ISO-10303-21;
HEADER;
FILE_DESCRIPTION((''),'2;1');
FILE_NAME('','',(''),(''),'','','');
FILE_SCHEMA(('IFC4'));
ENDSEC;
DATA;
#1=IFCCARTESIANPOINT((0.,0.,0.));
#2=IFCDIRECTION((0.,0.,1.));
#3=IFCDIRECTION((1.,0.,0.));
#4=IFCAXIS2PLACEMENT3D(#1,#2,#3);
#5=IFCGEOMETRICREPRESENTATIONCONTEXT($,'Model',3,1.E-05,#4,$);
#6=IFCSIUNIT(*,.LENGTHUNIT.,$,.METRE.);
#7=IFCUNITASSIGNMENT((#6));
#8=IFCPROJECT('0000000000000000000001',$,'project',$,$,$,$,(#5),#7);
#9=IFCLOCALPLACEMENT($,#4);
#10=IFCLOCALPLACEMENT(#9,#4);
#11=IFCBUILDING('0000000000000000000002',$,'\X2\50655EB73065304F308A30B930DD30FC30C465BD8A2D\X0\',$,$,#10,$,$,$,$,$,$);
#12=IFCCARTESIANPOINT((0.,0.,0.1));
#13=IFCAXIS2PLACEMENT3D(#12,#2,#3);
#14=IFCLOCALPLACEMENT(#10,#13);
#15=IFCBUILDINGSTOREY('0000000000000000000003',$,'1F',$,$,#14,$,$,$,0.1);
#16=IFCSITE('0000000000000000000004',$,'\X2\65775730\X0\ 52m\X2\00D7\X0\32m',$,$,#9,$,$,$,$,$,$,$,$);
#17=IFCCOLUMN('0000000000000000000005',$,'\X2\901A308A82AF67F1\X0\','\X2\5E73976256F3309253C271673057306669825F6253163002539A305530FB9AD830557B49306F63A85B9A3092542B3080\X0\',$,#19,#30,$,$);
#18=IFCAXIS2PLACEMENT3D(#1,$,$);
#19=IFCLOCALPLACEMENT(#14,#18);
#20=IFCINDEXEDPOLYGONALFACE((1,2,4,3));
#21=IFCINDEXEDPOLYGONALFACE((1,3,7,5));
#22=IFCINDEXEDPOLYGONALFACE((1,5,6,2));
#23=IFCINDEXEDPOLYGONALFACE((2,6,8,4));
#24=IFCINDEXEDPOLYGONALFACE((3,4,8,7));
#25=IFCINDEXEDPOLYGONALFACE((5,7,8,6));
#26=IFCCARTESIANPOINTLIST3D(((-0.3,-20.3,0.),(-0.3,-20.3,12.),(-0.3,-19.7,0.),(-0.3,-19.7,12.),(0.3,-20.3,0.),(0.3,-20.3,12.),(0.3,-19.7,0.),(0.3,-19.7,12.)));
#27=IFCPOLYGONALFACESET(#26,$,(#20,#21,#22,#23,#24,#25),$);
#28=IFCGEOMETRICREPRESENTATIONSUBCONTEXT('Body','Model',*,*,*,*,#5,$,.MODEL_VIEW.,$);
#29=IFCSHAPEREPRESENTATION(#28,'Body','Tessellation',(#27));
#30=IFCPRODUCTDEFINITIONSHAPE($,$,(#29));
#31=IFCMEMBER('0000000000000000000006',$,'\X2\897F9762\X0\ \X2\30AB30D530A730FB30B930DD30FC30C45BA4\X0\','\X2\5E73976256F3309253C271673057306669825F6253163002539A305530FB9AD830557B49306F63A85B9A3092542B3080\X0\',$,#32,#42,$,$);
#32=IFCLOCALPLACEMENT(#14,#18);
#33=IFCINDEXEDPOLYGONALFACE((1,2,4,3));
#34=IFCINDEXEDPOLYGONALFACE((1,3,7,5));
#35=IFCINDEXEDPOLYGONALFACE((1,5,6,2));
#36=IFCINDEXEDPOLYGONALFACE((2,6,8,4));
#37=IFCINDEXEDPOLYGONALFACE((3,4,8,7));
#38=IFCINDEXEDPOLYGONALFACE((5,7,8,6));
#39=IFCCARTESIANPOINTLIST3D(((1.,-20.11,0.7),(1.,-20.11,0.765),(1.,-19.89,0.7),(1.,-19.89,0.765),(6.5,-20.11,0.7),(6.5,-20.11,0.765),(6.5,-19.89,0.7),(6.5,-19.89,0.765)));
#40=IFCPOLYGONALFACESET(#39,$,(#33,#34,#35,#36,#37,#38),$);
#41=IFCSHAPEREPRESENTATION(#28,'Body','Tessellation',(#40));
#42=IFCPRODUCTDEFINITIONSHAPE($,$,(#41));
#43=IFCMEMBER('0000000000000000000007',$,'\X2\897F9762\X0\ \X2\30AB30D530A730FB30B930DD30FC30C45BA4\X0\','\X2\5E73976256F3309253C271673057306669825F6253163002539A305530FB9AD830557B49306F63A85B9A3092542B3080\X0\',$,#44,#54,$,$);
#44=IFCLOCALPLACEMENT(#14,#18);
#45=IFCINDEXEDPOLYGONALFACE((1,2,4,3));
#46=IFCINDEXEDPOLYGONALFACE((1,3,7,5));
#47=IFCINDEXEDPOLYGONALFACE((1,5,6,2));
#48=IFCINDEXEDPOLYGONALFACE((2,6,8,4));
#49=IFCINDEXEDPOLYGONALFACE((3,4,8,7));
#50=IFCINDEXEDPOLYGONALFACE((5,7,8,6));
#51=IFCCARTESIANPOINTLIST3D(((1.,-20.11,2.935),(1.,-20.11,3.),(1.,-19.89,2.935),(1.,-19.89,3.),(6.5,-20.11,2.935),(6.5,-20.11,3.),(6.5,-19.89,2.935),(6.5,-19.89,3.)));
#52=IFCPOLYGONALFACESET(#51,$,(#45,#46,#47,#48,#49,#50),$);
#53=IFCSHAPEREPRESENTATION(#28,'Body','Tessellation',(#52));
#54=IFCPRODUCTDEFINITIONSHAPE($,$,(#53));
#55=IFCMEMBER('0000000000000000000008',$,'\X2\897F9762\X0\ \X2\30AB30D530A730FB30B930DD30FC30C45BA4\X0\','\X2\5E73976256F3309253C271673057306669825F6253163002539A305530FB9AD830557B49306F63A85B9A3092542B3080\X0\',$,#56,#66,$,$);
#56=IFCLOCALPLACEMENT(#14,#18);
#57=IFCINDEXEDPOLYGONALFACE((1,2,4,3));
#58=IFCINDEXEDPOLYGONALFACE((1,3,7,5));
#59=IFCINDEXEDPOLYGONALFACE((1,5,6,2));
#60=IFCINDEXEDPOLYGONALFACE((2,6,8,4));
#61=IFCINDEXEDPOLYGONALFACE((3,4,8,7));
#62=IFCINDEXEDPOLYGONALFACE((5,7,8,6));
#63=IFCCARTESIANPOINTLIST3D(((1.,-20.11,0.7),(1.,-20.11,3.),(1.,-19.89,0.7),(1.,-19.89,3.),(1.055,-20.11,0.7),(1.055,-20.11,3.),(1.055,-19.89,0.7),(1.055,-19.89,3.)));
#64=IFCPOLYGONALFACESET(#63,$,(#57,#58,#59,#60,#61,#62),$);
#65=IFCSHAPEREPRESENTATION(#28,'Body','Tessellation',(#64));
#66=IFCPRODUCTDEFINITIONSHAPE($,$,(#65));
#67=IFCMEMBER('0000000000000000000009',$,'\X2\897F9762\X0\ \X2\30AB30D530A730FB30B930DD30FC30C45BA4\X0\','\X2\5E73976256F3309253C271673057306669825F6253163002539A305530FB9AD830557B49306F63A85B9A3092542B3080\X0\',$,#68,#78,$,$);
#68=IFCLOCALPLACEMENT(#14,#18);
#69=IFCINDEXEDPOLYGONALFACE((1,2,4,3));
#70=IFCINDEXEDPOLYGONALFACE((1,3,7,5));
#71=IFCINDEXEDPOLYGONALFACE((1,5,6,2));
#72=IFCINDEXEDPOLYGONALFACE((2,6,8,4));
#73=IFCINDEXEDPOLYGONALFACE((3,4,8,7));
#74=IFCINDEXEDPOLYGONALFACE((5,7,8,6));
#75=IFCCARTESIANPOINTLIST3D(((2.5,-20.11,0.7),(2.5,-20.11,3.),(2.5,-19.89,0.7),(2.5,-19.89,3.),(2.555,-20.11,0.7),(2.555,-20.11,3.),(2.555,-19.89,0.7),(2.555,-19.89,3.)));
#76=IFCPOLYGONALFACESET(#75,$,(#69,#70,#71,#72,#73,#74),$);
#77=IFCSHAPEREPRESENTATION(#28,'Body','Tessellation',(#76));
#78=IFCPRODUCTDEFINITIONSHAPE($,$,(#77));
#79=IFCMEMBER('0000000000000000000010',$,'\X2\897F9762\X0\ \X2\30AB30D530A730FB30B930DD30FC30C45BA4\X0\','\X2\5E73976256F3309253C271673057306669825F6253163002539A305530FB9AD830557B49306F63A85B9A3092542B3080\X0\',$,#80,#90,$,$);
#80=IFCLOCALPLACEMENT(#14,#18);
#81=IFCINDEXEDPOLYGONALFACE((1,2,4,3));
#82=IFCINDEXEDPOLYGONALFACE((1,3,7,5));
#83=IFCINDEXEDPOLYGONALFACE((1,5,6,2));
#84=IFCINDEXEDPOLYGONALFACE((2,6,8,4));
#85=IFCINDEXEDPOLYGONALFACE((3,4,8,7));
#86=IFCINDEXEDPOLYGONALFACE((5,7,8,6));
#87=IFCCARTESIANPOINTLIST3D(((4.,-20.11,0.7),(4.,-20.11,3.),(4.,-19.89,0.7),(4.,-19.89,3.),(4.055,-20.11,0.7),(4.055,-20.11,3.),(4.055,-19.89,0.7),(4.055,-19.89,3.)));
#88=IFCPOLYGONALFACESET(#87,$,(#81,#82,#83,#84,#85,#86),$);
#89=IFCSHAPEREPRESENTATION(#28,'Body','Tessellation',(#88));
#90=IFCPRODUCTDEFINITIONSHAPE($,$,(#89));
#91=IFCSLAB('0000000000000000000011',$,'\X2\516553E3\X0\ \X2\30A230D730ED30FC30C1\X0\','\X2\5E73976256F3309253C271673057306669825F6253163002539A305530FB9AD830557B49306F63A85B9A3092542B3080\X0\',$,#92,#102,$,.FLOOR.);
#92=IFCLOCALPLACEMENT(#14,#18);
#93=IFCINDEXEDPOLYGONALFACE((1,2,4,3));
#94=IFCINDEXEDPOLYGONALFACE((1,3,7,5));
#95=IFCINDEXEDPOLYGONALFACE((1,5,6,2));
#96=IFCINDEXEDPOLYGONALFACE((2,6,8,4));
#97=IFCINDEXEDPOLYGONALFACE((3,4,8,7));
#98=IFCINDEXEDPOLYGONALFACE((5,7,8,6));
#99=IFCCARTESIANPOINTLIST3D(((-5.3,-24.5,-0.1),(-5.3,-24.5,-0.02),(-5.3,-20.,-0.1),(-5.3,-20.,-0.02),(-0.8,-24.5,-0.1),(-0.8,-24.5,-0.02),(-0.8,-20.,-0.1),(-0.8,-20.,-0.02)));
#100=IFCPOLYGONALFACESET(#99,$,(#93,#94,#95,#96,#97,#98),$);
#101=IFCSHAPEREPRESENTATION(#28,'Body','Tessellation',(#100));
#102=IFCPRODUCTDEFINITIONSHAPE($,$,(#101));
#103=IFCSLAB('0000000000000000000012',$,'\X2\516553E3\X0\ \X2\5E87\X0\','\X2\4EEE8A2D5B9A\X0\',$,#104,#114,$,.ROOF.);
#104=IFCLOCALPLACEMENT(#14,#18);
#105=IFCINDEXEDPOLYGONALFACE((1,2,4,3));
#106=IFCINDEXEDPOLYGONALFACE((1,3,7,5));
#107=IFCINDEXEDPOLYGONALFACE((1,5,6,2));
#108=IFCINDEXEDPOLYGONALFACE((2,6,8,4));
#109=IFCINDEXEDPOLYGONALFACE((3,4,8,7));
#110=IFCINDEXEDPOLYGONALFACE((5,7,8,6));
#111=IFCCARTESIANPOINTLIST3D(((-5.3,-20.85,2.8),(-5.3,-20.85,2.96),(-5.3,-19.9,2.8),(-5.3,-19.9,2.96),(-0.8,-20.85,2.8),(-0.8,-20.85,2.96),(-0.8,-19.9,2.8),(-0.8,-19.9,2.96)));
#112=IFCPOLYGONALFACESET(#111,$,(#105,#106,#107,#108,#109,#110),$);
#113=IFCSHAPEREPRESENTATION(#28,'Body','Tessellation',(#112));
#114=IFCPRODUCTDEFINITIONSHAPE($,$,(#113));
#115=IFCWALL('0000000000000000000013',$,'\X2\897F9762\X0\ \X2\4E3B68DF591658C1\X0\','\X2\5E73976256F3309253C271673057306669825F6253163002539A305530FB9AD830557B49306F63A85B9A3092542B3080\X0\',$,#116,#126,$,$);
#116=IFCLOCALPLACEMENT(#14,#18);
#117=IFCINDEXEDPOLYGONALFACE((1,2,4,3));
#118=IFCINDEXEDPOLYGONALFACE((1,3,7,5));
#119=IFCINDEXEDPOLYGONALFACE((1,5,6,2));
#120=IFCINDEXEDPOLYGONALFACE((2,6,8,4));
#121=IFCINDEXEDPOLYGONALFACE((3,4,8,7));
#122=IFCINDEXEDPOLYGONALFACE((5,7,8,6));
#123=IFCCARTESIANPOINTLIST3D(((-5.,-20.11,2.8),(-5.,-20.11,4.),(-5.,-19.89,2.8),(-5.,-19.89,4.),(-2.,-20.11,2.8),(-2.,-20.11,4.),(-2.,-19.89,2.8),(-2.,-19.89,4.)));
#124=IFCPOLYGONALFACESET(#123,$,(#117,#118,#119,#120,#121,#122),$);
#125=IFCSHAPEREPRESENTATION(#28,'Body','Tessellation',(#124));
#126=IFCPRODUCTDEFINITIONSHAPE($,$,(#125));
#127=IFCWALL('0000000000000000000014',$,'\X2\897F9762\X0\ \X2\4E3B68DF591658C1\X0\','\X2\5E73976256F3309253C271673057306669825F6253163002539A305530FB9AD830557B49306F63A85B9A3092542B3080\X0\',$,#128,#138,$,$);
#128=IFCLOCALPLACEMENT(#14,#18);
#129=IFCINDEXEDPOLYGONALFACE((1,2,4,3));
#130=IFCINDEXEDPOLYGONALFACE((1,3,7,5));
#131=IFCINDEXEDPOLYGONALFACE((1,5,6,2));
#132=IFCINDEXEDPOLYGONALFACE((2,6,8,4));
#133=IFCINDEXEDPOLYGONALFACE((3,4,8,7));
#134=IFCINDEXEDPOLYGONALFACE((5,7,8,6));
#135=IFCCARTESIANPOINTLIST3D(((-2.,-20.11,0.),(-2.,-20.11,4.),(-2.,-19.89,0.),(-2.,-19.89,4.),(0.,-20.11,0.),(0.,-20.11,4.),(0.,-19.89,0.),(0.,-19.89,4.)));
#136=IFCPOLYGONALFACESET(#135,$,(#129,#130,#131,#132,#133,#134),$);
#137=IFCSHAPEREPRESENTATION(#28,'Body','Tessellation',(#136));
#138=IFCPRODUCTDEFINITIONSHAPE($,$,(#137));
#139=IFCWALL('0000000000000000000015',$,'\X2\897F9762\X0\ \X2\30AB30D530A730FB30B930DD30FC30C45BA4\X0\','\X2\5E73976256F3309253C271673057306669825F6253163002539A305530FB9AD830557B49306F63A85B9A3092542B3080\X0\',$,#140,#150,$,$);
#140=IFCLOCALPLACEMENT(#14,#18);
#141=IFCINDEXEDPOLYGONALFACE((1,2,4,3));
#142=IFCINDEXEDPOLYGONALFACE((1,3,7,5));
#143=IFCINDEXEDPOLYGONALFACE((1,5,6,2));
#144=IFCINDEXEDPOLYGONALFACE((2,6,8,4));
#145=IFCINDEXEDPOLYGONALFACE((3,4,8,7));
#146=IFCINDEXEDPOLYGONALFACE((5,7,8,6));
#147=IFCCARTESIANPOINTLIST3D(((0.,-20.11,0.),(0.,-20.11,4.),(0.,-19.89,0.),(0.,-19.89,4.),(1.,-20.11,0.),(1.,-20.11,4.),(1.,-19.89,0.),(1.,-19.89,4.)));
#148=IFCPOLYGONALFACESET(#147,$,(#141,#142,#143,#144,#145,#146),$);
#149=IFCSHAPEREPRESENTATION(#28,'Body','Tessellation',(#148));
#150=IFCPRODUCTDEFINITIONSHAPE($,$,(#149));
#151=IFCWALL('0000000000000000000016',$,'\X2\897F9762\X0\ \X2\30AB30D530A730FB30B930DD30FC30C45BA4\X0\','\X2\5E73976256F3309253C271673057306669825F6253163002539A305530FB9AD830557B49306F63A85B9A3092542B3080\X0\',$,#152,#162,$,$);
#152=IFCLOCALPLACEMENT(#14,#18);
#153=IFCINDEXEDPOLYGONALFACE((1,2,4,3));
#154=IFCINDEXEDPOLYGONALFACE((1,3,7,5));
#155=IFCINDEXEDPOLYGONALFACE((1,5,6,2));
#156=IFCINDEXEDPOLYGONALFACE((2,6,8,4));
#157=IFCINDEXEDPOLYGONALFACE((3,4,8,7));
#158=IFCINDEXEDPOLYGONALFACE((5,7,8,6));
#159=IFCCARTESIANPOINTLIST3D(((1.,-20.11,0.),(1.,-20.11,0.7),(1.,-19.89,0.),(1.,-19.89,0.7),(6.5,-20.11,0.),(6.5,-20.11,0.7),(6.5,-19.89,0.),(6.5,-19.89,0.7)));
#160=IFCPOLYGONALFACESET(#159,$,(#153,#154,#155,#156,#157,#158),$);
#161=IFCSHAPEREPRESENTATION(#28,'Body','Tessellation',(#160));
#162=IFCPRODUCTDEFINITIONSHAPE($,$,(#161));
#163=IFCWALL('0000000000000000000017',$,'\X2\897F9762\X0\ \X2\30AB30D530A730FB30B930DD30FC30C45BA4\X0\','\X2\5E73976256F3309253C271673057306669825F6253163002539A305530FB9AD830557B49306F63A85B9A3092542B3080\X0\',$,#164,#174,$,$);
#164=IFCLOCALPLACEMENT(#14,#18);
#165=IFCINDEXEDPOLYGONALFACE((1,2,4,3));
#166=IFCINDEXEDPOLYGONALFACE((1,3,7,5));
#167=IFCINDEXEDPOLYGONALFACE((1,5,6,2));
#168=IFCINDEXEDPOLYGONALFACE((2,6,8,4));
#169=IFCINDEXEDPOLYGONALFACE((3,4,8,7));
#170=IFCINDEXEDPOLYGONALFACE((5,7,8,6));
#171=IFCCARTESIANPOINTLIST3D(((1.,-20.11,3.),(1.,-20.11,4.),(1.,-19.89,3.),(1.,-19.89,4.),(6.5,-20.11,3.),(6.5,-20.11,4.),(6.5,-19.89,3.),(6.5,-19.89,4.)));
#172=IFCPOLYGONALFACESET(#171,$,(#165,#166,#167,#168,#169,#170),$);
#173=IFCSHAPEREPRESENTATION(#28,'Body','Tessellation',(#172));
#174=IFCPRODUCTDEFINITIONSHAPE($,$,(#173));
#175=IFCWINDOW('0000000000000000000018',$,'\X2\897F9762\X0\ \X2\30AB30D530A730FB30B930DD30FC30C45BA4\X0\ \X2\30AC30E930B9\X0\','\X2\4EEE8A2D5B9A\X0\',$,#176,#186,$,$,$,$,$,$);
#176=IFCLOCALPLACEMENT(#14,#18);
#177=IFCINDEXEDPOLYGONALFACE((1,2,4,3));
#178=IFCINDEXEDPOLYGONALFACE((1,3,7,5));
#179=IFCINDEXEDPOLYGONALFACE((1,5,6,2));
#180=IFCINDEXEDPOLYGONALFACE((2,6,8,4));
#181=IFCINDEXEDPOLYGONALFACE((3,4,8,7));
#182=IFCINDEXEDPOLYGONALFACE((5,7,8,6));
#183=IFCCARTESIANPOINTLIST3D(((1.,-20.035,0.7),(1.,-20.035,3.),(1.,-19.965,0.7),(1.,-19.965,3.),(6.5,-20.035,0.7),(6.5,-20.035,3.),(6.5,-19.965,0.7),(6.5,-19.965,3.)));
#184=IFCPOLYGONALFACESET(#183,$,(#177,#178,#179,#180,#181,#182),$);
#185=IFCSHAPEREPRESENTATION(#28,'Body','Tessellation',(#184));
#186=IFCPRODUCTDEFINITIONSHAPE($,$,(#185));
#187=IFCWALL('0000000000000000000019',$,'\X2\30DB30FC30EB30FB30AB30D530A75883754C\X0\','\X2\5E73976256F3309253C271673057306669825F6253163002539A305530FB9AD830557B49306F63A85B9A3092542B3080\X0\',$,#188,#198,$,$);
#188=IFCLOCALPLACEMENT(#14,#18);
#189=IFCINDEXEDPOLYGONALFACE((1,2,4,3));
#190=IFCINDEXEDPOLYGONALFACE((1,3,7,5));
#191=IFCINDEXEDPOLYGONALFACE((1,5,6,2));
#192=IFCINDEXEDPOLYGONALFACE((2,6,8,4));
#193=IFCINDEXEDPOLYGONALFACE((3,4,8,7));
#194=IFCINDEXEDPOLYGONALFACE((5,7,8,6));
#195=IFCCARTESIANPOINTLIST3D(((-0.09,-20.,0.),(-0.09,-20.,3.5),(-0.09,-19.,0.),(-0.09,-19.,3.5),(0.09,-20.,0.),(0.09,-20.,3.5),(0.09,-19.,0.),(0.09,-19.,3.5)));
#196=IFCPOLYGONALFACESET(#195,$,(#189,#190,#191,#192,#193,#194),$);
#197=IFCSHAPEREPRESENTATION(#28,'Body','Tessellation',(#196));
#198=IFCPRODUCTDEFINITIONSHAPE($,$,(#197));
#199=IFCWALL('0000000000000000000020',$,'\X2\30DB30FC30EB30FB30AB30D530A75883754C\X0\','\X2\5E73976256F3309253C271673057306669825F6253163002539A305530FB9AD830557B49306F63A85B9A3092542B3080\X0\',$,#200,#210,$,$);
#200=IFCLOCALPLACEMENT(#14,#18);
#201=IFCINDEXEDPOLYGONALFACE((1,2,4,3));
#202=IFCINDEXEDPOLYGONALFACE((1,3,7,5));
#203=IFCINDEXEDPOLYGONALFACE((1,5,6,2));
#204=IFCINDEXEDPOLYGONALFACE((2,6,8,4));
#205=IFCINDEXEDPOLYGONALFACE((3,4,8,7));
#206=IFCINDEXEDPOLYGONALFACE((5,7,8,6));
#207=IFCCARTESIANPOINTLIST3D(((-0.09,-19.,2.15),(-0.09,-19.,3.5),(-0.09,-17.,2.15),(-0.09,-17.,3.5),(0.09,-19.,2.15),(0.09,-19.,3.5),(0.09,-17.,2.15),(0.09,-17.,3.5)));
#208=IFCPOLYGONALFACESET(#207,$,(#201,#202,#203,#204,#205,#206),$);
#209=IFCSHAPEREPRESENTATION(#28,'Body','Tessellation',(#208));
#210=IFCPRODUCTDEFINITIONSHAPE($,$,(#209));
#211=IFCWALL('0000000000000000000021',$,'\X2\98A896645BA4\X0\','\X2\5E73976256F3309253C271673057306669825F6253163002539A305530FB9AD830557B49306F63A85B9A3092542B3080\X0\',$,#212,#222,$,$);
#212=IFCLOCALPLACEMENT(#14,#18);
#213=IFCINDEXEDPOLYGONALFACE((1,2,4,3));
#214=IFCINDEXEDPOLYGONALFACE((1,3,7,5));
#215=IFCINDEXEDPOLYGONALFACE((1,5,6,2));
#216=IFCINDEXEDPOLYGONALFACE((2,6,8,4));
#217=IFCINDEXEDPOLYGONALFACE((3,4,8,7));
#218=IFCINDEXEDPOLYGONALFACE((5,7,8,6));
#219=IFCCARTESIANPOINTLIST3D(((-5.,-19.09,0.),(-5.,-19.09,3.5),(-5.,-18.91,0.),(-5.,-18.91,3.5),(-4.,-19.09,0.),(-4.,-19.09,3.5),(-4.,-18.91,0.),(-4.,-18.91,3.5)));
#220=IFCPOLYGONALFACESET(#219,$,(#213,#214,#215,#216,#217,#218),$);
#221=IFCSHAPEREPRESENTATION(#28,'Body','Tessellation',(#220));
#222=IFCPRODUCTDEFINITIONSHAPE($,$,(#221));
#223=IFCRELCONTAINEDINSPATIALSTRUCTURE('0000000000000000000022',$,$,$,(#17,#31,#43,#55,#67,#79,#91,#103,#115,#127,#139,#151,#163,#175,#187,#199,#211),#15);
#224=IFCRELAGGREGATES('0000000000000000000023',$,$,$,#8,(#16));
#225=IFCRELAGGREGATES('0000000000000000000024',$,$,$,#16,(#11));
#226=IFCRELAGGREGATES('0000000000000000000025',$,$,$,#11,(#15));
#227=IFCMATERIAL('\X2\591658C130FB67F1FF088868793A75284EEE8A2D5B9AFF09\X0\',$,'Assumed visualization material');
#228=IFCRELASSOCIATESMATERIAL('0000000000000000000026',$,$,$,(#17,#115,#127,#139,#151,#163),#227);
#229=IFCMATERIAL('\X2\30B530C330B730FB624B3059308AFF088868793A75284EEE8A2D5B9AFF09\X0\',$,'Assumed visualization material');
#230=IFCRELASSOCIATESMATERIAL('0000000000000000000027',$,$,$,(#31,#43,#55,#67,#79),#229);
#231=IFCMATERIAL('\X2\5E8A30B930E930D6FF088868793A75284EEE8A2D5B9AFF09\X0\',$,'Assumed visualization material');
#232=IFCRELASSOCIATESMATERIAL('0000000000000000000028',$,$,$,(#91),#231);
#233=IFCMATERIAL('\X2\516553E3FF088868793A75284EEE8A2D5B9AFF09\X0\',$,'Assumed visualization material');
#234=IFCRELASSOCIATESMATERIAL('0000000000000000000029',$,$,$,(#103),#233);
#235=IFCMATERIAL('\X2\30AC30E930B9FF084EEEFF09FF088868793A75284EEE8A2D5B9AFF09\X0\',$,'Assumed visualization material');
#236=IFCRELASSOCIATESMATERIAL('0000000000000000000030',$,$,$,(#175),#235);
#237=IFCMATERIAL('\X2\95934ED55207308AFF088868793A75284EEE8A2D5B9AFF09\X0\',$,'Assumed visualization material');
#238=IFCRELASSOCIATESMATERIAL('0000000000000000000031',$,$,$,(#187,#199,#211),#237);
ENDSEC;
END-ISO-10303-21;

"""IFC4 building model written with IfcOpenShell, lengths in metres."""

from ifc_helpers import new_model, si_unit, frame, origin_with_axes, place, context, subcontext, project, spatial, rectangle, extrude, material, element, save


model = new_model("IFC4")

# Units and contexts
model_context = context("Model", 3, precision=1e-05, world=origin_with_axes())
body_context = subcontext(model_context, "Body", "Model", "MODEL_VIEW")
ifc_project = project(units=[si_unit("LENGTHUNIT", "METRE")], contexts=[model_context])

# Site, building, storey
site_placement = place(None, origin_with_axes())
site = spatial("IfcSite", under=ifc_project, at=site_placement, Name="敷地 52m×32m")
building_placement = place(site_placement, origin_with_axes())
building = spatial("IfcBuilding", under=site, at=building_placement, Name="健康づくりスポーツ施設")
storey_placement = place(building_placement, frame((0.0, 0.0, 0.1), z_axis=(0.0, 0.0, 1.0), x_axis=(1.0, 0.0, 0.0)))
storey = spatial("IfcBuildingStorey", under=building, at=storey_placement, Name="1F", Elevation=0.1)

# Column
ifc_material_1 = material(Name="外壁・柱（表示用仮設定）", Category="Assumed visualization material")
column_placement = place(storey_placement, frame((0.0, -20.0, 0.0), z_axis=(0.0, 0.0, 1.0), x_axis=(1.0, 0.0, 0.0)))
element("IfcColumn", 1, at=column_placement, inside=storey, material=ifc_material_1, Name="通り芯柱", Description="平面図を参照して概形化。厚さ・高さ等は推定を含む", context=body_context, shape_type="SweptSolid", body=[
    extrude(rectangle(XDim=0.6, YDim=0.6), origin_with_axes(), (0.0, 0.0, 1.0), 12.0),
])

# Members
ifc_material_2 = material(Name="サッシ・手すり（表示用仮設定）", Category="Assumed visualization material")
member_1_placement = place(storey_placement, frame((3.75, -20.0, 0.7), z_axis=(0.0, 0.0, 1.0), x_axis=(1.0, 0.0, 0.0)))
element("IfcMember", 2, at=member_1_placement, inside=storey, material=ifc_material_2, Name="西面 カフェ・スポーツ室", Description="平面図を参照して概形化。厚さ・高さ等は推定を含む", context=body_context, shape_type="SweptSolid", body=[
    extrude(rectangle(XDim=5.5, YDim=0.22), origin_with_axes(), (0.0, 0.0, 1.0), 0.065),
])
member_2_placement = place(storey_placement, frame((3.75, -20.0, 2.935), z_axis=(0.0, 0.0, 1.0), x_axis=(1.0, 0.0, 0.0)))
element("IfcMember", 3, at=member_2_placement, inside=storey, material=ifc_material_2, Name="西面 カフェ・スポーツ室", Description="平面図を参照して概形化。厚さ・高さ等は推定を含む", context=body_context, shape_type="SweptSolid", body=[
    extrude(rectangle(XDim=5.5, YDim=0.22), origin_with_axes(), (0.0, 0.0, 1.0), 0.065),
])
for number, where, z_axis, x_axis, name in (
    (4, (1.0275, -20.0, 0.7), (0.0, 0.0, 1.0), (1.0, 0.0, 0.0), "西面 カフェ・スポーツ室"),
    (5, (2.5275, -20.0, 0.7), (0.0, 0.0, 1.0), (1.0, 0.0, 0.0), "西面 カフェ・スポーツ室"),
    (6, (4.0275, -20.0, 0.7), (0.0, 0.0, 1.0), (1.0, 0.0, 0.0), "西面 カフェ・スポーツ室"),
):
    element("IfcMember", number, at=place(storey_placement, frame(where, z_axis=z_axis, x_axis=x_axis)), inside=storey, material=ifc_material_2, Name=name, Description="平面図を参照して概形化。厚さ・高さ等は推定を含む", context=body_context, shape_type="SweptSolid", body=[
        extrude(rectangle(XDim=0.055, YDim=0.22), origin_with_axes(), (0.0, 0.0, 1.0), 2.3),
    ])

# Slabs
ifc_material_3 = material(Name="床スラブ（表示用仮設定）", Category="Assumed visualization material")
slab_1_placement = place(storey_placement, frame((-3.05, -22.25, -0.1), z_axis=(0.0, 0.0, 1.0), x_axis=(1.0, 0.0, 0.0)))
element("IfcSlab", 7, at=slab_1_placement, inside=storey, material=ifc_material_3, Name="入口 アプローチ", Description="平面図を参照して概形化。厚さ・高さ等は推定を含む", PredefinedType="FLOOR", context=body_context, shape_type="SweptSolid", body=[
    extrude(rectangle(XDim=4.5, YDim=4.5), origin_with_axes(), (0.0, 0.0, 1.0), 0.08),
])
ifc_material_4 = material(Name="入口（表示用仮設定）", Category="Assumed visualization material")
slab_2_placement = place(storey_placement, frame((-3.05, -20.375, 2.8), z_axis=(0.0, 0.0, 1.0), x_axis=(1.0, 0.0, 0.0)))
element("IfcSlab", 8, at=slab_2_placement, inside=storey, material=ifc_material_4, Name="入口 庇", Description="仮設定", PredefinedType="ROOF", context=body_context, shape_type="SweptSolid", body=[
    extrude(rectangle(XDim=4.5, YDim=0.95), origin_with_axes(), (0.0, 0.0, 1.0), 0.16),
])

# Walls
wall_1_placement = place(storey_placement, frame((-3.5, -20.0, 2.8), z_axis=(0.0, 0.0, 1.0), x_axis=(1.0, 0.0, 0.0)))
element("IfcWall", 9, at=wall_1_placement, inside=storey, material=ifc_material_1, Name="西面 主棟外壁", Description="平面図を参照して概形化。厚さ・高さ等は推定を含む", context=body_context, shape_type="SweptSolid", body=[
    extrude(rectangle(XDim=3.0, YDim=0.22), origin_with_axes(), (0.0, 0.0, 1.0), 1.2),
])
wall_2_placement = place(storey_placement, frame((-1.0, -20.0, 0.0), z_axis=(0.0, 0.0, 1.0), x_axis=(1.0, 0.0, 0.0)))
element("IfcWall", 10, at=wall_2_placement, inside=storey, material=ifc_material_1, Name="西面 主棟外壁", Description="平面図を参照して概形化。厚さ・高さ等は推定を含む", context=body_context, shape_type="SweptSolid", body=[
    extrude(rectangle(XDim=2.0, YDim=0.22), origin_with_axes(), (0.0, 0.0, 1.0), 4.0),
])
wall_3_placement = place(storey_placement, frame((0.5, -20.0, 0.0), z_axis=(0.0, 0.0, 1.0), x_axis=(1.0, 0.0, 0.0)))
element("IfcWall", 11, at=wall_3_placement, inside=storey, material=ifc_material_1, Name="西面 カフェ・スポーツ室", Description="平面図を参照して概形化。厚さ・高さ等は推定を含む", context=body_context, shape_type="SweptSolid", body=[
    extrude(rectangle(XDim=1.0, YDim=0.22), origin_with_axes(), (0.0, 0.0, 1.0), 4.0),
])
wall_4_placement = place(storey_placement, frame((3.75, -20.0, 0.0), z_axis=(0.0, 0.0, 1.0), x_axis=(1.0, 0.0, 0.0)))
element("IfcWall", 12, at=wall_4_placement, inside=storey, material=ifc_material_1, Name="西面 カフェ・スポーツ室", Description="平面図を参照して概形化。厚さ・高さ等は推定を含む", context=body_context, shape_type="SweptSolid", body=[
    extrude(rectangle(XDim=5.5, YDim=0.22), origin_with_axes(), (0.0, 0.0, 1.0), 0.7),
])
wall_5_placement = place(storey_placement, frame((3.75, -20.0, 3.0), z_axis=(0.0, 0.0, 1.0), x_axis=(1.0, 0.0, 0.0)))
element("IfcWall", 13, at=wall_5_placement, inside=storey, material=ifc_material_1, Name="西面 カフェ・スポーツ室", Description="平面図を参照して概形化。厚さ・高さ等は推定を含む", context=body_context, shape_type="SweptSolid", body=[
    extrude(rectangle(XDim=5.5, YDim=0.22), origin_with_axes(), (0.0, 0.0, 1.0), 1.0),
])

# Window
ifc_material_5 = material(Name="ガラス（仮）（表示用仮設定）", Category="Assumed visualization material")
window_placement = place(storey_placement, frame((3.75, -20.0, 0.7), z_axis=(0.0, 0.0, 1.0), x_axis=(1.0, 0.0, 0.0)))
element("IfcWindow", 14, at=window_placement, inside=storey, material=ifc_material_5, Name="西面 カフェ・スポーツ室 ガラス", Description="仮設定", context=body_context, shape_type="SweptSolid", body=[
    extrude(rectangle(XDim=5.5, YDim=0.07), origin_with_axes(), (0.0, 0.0, 1.0), 2.3),
])

# Walls
ifc_material_6 = material(Name="間仕切り（表示用仮設定）", Category="Assumed visualization material")
wall_6_placement = place(storey_placement, frame((0.0, -19.5, 0.0), z_axis=(0.0, 0.0, 1.0), x_axis=(1.0, 0.0, 0.0)))
element("IfcWall", 15, at=wall_6_placement, inside=storey, material=ifc_material_6, Name="ホール・カフェ境界", Description="平面図を参照して概形化。厚さ・高さ等は推定を含む", context=body_context, shape_type="SweptSolid", body=[
    extrude(rectangle(XDim=0.18, YDim=1.0), origin_with_axes(), (0.0, 0.0, 1.0), 3.5),
])
wall_7_placement = place(storey_placement, frame((0.0, -18.0, 2.15), z_axis=(0.0, 0.0, 1.0), x_axis=(1.0, 0.0, 0.0)))
element("IfcWall", 16, at=wall_7_placement, inside=storey, material=ifc_material_6, Name="ホール・カフェ境界", Description="平面図を参照して概形化。厚さ・高さ等は推定を含む", context=body_context, shape_type="SweptSolid", body=[
    extrude(rectangle(XDim=0.18, YDim=2.0), origin_with_axes(), (0.0, 0.0, 1.0), 1.35),
])
wall_8_placement = place(storey_placement, frame((-4.5, -19.0, 0.0), z_axis=(0.0, 0.0, 1.0), x_axis=(1.0, 0.0, 0.0)))
element("IfcWall", 17, at=wall_8_placement, inside=storey, material=ifc_material_6, Name="風除室", Description="平面図を参照して概形化。厚さ・高さ等は推定を含む", context=body_context, shape_type="SweptSolid", body=[
    extrude(rectangle(XDim=1.0, YDim=0.18), origin_with_axes(), (0.0, 0.0, 1.0), 3.5),
])

save(model, "model.ifc")
